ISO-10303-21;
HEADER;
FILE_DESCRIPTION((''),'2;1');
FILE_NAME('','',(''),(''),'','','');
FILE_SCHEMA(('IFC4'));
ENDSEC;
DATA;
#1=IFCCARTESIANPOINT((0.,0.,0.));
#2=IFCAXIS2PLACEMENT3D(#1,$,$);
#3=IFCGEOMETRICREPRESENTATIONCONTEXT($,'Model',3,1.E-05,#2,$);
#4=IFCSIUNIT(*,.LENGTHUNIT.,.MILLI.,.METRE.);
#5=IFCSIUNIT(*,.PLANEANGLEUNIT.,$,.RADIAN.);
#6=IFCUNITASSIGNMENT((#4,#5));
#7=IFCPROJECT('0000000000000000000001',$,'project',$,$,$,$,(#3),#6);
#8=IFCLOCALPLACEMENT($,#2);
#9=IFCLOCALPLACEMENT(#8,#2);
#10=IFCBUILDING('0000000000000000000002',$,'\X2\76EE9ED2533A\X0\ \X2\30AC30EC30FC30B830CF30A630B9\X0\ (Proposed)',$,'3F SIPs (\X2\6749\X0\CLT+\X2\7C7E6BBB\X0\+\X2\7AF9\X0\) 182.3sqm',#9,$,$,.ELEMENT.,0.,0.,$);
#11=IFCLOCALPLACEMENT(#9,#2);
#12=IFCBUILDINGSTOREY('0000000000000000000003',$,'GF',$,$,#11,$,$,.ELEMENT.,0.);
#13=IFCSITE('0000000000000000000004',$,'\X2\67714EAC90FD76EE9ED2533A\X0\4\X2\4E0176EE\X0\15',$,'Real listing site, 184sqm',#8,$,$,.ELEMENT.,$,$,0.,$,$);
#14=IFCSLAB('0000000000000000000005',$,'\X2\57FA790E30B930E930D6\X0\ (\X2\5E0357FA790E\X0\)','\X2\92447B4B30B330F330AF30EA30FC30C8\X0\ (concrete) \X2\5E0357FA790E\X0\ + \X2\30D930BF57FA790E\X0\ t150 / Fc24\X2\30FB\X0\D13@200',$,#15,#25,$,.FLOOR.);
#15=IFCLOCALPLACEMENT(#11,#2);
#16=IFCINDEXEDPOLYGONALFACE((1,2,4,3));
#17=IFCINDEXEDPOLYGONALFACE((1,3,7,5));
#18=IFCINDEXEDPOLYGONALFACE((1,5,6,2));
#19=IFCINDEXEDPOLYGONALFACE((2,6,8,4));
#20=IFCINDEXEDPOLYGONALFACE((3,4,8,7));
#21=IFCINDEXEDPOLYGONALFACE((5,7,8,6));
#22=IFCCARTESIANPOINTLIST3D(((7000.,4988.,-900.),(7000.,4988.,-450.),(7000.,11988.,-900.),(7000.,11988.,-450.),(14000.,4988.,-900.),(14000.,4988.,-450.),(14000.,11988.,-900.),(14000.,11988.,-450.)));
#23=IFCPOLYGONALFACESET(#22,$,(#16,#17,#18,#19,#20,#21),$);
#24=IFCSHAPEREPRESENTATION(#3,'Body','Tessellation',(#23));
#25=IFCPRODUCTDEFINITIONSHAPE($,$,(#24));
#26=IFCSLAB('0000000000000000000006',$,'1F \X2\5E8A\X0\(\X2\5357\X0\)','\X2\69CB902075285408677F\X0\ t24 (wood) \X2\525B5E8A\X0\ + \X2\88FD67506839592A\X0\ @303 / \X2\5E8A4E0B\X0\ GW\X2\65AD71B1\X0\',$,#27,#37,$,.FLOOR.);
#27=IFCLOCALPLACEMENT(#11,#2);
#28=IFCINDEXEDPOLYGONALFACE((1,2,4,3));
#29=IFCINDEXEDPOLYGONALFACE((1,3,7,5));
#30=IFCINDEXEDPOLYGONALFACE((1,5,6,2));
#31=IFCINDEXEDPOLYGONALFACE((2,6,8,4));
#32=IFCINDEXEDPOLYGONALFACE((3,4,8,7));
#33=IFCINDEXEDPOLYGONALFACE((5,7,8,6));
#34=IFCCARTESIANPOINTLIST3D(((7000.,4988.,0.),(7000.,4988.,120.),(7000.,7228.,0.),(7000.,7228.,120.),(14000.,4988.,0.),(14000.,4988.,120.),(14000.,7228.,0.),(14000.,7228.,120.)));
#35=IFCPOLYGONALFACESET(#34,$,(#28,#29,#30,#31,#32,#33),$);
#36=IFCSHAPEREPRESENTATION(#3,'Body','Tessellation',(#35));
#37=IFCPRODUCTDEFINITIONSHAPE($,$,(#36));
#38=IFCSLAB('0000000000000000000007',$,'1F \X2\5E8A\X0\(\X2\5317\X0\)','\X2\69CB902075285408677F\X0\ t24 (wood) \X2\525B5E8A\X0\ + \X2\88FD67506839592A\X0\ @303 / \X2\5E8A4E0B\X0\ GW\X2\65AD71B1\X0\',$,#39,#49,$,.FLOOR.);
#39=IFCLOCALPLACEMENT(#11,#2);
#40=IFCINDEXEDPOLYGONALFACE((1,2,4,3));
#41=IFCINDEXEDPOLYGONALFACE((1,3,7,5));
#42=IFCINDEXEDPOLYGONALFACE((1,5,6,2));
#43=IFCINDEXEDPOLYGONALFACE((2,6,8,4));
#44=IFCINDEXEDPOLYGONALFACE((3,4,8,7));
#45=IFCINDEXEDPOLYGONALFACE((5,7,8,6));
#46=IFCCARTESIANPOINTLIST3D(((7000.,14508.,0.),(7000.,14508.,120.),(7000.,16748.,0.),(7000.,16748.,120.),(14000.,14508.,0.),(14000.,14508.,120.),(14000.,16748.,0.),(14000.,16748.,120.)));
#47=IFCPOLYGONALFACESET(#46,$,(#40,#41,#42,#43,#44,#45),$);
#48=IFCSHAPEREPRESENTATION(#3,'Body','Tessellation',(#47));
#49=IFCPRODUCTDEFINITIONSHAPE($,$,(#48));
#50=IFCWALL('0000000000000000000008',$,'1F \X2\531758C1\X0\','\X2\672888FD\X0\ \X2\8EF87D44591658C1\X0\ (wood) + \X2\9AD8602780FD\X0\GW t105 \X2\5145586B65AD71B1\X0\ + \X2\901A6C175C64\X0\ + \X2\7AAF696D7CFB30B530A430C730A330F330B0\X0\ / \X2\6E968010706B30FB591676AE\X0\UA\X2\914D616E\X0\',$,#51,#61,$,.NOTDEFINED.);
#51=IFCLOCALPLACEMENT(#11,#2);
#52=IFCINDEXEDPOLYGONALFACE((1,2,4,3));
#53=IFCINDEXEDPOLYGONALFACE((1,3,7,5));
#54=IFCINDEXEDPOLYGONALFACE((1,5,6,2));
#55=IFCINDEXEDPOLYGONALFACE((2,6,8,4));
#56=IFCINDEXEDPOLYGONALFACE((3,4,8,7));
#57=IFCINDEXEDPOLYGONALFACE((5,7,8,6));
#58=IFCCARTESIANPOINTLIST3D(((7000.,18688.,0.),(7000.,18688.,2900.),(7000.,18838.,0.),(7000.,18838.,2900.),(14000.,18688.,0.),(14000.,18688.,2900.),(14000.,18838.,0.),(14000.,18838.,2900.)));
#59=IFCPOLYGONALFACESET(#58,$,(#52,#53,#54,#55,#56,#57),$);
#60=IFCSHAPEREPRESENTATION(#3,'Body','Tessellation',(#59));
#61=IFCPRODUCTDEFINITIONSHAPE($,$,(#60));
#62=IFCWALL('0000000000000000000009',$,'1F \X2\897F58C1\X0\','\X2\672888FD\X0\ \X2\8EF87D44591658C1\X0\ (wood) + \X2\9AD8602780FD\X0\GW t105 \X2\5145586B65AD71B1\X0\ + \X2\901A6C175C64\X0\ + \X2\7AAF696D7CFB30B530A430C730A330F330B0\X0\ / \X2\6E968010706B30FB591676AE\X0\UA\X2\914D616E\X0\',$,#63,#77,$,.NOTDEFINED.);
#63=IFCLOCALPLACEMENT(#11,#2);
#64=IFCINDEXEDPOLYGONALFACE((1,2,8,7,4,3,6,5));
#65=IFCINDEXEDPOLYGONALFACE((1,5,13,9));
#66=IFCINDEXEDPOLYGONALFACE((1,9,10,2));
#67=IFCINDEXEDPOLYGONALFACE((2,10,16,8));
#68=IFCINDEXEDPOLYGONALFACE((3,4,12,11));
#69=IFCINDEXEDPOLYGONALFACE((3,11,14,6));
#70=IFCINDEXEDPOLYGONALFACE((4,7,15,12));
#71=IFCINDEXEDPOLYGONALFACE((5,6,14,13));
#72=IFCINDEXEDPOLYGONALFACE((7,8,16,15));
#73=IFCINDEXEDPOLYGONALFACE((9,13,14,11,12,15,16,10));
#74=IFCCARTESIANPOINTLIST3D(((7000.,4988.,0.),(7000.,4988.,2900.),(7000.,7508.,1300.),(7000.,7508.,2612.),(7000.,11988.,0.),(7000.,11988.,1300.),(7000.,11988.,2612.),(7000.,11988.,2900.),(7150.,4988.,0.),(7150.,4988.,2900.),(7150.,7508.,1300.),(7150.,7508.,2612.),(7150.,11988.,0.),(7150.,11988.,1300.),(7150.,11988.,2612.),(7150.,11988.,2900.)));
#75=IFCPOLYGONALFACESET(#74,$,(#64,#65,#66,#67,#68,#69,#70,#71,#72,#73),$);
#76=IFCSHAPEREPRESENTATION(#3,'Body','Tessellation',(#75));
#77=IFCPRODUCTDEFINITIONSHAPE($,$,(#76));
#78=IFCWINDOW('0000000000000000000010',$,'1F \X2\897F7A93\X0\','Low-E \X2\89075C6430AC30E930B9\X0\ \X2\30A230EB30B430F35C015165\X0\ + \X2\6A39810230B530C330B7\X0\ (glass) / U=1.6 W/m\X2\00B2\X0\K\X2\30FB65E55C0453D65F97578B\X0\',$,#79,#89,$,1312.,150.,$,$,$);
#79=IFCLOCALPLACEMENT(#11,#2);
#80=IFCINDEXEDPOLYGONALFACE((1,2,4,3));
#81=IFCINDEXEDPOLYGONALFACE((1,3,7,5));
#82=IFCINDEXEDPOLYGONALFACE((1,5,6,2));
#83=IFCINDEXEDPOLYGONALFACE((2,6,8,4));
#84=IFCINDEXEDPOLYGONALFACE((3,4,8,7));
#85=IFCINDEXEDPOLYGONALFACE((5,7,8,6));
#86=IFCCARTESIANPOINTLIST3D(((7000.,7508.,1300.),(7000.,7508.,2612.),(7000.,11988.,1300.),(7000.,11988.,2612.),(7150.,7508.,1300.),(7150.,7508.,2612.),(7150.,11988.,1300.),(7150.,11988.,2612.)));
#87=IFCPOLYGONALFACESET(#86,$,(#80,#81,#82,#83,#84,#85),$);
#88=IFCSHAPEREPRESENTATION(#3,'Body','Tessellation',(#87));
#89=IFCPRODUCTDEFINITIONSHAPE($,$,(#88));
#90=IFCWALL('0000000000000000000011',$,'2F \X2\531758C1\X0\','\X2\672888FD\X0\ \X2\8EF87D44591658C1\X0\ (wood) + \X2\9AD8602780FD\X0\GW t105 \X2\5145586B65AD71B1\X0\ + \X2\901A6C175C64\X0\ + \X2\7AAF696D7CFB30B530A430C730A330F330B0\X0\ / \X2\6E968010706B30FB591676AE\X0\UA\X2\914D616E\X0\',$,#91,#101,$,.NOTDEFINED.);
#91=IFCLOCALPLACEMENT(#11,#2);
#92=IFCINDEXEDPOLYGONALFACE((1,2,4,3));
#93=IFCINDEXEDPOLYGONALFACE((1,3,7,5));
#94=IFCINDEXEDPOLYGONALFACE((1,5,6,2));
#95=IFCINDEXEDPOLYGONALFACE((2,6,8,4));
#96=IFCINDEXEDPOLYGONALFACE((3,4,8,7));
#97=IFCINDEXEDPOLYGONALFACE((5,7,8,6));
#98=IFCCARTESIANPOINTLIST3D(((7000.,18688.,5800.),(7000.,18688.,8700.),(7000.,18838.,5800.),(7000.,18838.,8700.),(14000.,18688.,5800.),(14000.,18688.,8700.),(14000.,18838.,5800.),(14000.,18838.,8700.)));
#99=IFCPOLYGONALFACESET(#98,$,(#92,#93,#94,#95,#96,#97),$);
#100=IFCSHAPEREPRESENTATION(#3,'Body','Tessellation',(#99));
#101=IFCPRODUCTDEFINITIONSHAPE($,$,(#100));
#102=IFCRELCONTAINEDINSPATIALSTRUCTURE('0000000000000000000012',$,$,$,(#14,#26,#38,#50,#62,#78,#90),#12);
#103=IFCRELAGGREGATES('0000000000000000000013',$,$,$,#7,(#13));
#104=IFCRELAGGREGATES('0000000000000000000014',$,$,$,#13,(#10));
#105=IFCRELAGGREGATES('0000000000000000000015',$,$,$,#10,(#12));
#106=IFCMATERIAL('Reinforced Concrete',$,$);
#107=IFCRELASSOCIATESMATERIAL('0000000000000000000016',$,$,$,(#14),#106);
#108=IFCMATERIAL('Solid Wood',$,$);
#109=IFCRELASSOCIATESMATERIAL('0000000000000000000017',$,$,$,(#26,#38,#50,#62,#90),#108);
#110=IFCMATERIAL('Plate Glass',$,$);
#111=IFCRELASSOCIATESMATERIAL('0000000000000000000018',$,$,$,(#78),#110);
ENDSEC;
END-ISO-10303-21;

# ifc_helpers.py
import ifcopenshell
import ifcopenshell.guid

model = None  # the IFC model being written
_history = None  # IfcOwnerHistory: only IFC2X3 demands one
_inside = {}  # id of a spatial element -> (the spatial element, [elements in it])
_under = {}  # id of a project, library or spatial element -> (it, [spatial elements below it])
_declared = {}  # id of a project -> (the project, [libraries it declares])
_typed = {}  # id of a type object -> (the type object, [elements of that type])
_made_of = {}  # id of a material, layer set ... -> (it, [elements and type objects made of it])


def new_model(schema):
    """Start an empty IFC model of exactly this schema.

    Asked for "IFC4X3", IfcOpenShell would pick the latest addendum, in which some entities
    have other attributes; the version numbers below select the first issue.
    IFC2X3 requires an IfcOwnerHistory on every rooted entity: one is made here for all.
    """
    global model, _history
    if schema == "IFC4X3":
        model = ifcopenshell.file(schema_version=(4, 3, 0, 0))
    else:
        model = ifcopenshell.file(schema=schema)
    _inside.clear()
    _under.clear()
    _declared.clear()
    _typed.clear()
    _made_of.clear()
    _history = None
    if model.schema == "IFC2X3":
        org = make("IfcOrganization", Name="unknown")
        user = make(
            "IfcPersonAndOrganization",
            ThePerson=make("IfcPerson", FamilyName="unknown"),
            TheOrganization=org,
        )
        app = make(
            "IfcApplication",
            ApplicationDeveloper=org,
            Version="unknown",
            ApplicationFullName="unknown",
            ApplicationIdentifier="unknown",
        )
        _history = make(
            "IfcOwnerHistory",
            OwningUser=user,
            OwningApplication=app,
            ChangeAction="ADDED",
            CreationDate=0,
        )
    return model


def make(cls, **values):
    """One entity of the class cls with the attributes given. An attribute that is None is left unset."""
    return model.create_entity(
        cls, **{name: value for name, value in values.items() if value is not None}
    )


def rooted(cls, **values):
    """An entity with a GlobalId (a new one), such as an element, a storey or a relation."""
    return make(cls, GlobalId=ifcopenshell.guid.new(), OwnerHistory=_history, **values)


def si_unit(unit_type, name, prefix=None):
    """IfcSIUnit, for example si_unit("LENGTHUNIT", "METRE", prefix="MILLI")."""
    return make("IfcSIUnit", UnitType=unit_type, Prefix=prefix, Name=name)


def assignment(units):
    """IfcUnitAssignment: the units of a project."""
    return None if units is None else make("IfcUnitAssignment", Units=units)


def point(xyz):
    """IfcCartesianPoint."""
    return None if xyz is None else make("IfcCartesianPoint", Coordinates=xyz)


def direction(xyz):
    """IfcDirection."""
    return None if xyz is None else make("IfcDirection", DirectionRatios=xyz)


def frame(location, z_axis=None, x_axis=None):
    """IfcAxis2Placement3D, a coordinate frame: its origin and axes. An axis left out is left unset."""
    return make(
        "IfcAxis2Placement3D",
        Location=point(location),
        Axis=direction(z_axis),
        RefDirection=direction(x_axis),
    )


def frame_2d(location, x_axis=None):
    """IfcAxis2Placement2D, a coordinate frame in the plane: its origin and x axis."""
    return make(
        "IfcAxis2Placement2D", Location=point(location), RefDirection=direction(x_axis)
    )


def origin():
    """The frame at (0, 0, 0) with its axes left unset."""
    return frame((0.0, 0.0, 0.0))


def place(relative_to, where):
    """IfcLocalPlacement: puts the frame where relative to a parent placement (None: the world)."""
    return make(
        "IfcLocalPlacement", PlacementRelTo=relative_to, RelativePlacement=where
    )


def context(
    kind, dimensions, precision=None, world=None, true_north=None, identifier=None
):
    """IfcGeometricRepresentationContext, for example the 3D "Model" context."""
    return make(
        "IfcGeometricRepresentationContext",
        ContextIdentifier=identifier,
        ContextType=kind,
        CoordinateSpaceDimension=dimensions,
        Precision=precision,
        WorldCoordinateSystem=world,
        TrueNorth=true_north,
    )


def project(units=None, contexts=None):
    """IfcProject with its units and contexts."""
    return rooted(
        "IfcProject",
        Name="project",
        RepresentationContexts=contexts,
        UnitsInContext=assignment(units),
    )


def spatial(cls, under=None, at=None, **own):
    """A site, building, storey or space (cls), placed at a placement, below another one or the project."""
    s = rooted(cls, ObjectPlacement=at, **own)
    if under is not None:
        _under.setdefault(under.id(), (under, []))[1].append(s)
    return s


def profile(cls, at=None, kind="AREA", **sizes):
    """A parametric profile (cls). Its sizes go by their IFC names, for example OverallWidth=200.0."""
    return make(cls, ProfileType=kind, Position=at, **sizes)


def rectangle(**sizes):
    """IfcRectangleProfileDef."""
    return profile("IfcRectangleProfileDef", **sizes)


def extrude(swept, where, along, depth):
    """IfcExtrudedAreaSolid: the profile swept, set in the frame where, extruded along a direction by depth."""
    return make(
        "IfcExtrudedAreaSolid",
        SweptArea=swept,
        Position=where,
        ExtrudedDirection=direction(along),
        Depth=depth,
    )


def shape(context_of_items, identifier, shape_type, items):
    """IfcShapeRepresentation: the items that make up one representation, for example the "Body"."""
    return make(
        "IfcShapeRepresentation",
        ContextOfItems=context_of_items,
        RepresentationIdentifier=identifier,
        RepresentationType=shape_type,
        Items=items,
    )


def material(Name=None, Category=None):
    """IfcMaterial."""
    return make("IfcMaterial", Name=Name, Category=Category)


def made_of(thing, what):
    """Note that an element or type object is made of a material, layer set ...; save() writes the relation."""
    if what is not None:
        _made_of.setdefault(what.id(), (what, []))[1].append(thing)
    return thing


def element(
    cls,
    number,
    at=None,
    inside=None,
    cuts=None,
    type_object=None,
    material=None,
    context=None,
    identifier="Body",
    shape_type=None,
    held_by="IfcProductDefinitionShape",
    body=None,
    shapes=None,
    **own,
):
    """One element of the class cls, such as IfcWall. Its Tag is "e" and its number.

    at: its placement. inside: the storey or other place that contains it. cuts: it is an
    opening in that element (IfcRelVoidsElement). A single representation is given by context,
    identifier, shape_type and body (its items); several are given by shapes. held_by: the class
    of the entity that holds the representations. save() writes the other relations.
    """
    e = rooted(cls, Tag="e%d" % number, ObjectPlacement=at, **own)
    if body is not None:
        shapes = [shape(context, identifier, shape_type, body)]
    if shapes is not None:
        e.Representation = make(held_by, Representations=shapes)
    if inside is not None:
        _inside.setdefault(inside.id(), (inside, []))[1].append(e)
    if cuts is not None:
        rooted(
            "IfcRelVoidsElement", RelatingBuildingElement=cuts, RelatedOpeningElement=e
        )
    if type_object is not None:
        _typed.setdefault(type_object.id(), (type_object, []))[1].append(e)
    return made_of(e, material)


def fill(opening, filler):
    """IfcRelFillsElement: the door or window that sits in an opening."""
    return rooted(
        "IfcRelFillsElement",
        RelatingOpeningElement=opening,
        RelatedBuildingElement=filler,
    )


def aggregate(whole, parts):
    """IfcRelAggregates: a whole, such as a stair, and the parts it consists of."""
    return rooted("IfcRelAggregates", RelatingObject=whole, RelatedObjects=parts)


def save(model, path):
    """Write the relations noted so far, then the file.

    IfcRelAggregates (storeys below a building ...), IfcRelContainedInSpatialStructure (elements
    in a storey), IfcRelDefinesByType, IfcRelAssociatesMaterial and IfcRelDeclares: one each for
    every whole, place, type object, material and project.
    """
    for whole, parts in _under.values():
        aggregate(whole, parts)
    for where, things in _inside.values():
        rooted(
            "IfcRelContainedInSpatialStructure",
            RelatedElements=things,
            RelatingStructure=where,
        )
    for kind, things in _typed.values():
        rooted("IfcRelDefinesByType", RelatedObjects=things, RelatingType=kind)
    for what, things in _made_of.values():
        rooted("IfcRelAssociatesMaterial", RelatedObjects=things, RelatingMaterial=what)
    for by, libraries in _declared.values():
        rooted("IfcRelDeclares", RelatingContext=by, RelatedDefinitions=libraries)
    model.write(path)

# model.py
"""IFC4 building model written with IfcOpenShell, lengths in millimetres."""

from ifc_helpers import new_model, si_unit, frame, frame_2d, origin, place, context, project, spatial, rectangle, extrude, material, element, fill, save


model = new_model("IFC4")

# Units and contexts
model_context = context("Model", 3, precision=1e-05, world=origin())
ifc_project = project(units=[si_unit("LENGTHUNIT", "METRE", prefix="MILLI"), si_unit("PLANEANGLEUNIT", "RADIAN")], contexts=[model_context])

# Site, building, storey
site_placement = place(None, origin())
site = spatial("IfcSite", under=ifc_project, at=site_placement, Name="東京都目黒区4丁目15", ObjectType="Real listing site, 184sqm", CompositionType="ELEMENT", RefElevation=0.0)
building_placement = place(site_placement, origin())
building = spatial("IfcBuilding", under=site, at=building_placement, Name="目黒区 ガレージハウス (Proposed)", ObjectType="3F SIPs (杉CLT+籾殻+竹) 182.3sqm", CompositionType="ELEMENT", ElevationOfRefHeight=0.0, ElevationOfTerrain=0.0)
storey_placement = place(building_placement, origin())
storey = spatial("IfcBuildingStorey", under=building, at=storey_placement, Name="GF", CompositionType="ELEMENT", Elevation=0.0)

# Slabs
ifc_material_1 = material(Name="Reinforced Concrete")
slab_1_placement = place(storey_placement, frame((3500.0, 2494.0, -450.0)))
element("IfcSlab", 1, at=slab_1_placement, inside=storey, material=ifc_material_1, Name="基礎スラブ (布基礎)", Description="鉄筋コンクリート (concrete) 布基礎 + ベタ基礎 t150 / Fc24・D13@200", PredefinedType="FLOOR", context=model_context, shape_type="SweptSolid", body=[
    extrude(rectangle(XDim=7000.0, YDim=7000.0, at=frame_2d((3500.0, 3500.0))), frame((3500.0, 2494.0, -450.0)), (0.0, 0.0, 1.0), 450.0),
])
ifc_material_2 = material(Name="Solid Wood")
slab_2_placement = place(storey_placement, frame((3500.0, 2494.0, 0.0)))
element("IfcSlab", 2, at=slab_2_placement, inside=storey, material=ifc_material_2, Name="1F 床(南)", Description="構造用合板 t24 (wood) 剛床 + 製材根太 @303 / 床下 GW断熱", PredefinedType="FLOOR", context=model_context, shape_type="SweptSolid", body=[
    extrude(rectangle(XDim=7000.0, YDim=2240.0, at=frame_2d((3500.0, 1120.0))), frame((3500.0, 2494.0, 0.0)), (0.0, 0.0, 1.0), 120.0),
])
slab_3_placement = place(storey_placement, frame((3500.0, 7254.0, 0.0)))
element("IfcSlab", 3, at=slab_3_placement, inside=storey, material=ifc_material_2, Name="1F 床(北)", Description="構造用合板 t24 (wood) 剛床 + 製材根太 @303 / 床下 GW断熱", PredefinedType="FLOOR", context=model_context, shape_type="SweptSolid", body=[
    extrude(rectangle(XDim=7000.0, YDim=2240.0, at=frame_2d((3500.0, 1120.0))), frame((3500.0, 7254.0, 0.0)), (0.0, 0.0, 1.0), 120.0),
])

# Shared definitions
ifc_material_3 = material(Name="Plate Glass")

# Wall
wall_1_placement = place(storey_placement, frame((3500.0, 9344.0, 0.0)))
element("IfcWall", 4, at=wall_1_placement, inside=storey, material=ifc_material_2, Name="1F 北壁", Description="木製 軸組外壁 (wood) + 高性能GW t105 充填断熱 + 通気層 + 窯業系サイディング / 準耐火・外皮UA配慮", PredefinedType="NOTDEFINED", context=model_context, shape_type="SweptSolid", body=[
    extrude(rectangle(XDim=7000.0, YDim=150.0, at=frame_2d((3500.0, 75.0))), frame((3500.0, 9344.0, 0.0)), (0.0, 0.0, 1.0), 2900.0),
])

# Wall, opening, window
wall_2_placement = place(storey_placement, frame((3500.0, 2494.0, 0.0)))
wall_2 = element("IfcWall", 5, at=wall_2_placement, inside=storey, material=ifc_material_2, Name="1F 西壁", Description="木製 軸組外壁 (wood) + 高性能GW t105 充填断熱 + 通気層 + 窯業系サイディング / 準耐火・外皮UA配慮", PredefinedType="NOTDEFINED", context=model_context, shape_type="SweptSolid", body=[
    extrude(rectangle(XDim=150.0, YDim=7000.0, at=frame_2d((75.0, 3500.0))), frame((3500.0, 2494.0, 0.0)), (0.0, 0.0, 1.0), 2900.0),
])
opening_1_placement = place(storey_placement, frame((3500.0, 3754.0, 650.0)))
opening_1 = element("IfcOpeningElement", 6, at=opening_1_placement, cuts=wall_2, PredefinedType="NOTDEFINED", context=model_context, shape_type="SweptSolid", body=[
    extrude(rectangle(XDim=150.0, YDim=4480.0, at=frame_2d((75.0, 2240.0))), frame((3500.0, 3754.0, 650.0)), (0.0, 0.0, 1.0), 1312.0),
])
window_1_placement = place(storey_placement, frame((3500.0, 3754.0, 650.0)))
window_1 = element("IfcWindow", 7, at=window_1_placement, inside=storey, material=ifc_material_3, Name="1F 西窓", Description="Low-E 複層ガラス アルゴン封入 + 樹脂サッシ (glass) / U=1.6 W/m²K・日射取得型", OverallHeight=1312.0, OverallWidth=150.0, context=model_context, shape_type="SweptSolid", body=[
    extrude(rectangle(XDim=150.0, YDim=4480.0, at=frame_2d((75.0, 2240.0))), frame((3500.0, 3754.0, 650.0)), (0.0, 0.0, 1.0), 1312.0),
])
fill(opening_1, window_1)

# Wall
wall_3_placement = place(storey_placement, frame((3500.0, 9344.0, 2900.0)))
element("IfcWall", 8, at=wall_3_placement, inside=storey, material=ifc_material_2, Name="2F 北壁", Description="木製 軸組外壁 (wood) + 高性能GW t105 充填断熱 + 通気層 + 窯業系サイディング / 準耐火・外皮UA配慮", PredefinedType="NOTDEFINED", context=model_context, shape_type="SweptSolid", body=[
    extrude(rectangle(XDim=7000.0, YDim=150.0, at=frame_2d((3500.0, 75.0))), frame((3500.0, 9344.0, 2900.0)), (0.0, 0.0, 1.0), 2900.0),
])

save(model, "model.ifc")
